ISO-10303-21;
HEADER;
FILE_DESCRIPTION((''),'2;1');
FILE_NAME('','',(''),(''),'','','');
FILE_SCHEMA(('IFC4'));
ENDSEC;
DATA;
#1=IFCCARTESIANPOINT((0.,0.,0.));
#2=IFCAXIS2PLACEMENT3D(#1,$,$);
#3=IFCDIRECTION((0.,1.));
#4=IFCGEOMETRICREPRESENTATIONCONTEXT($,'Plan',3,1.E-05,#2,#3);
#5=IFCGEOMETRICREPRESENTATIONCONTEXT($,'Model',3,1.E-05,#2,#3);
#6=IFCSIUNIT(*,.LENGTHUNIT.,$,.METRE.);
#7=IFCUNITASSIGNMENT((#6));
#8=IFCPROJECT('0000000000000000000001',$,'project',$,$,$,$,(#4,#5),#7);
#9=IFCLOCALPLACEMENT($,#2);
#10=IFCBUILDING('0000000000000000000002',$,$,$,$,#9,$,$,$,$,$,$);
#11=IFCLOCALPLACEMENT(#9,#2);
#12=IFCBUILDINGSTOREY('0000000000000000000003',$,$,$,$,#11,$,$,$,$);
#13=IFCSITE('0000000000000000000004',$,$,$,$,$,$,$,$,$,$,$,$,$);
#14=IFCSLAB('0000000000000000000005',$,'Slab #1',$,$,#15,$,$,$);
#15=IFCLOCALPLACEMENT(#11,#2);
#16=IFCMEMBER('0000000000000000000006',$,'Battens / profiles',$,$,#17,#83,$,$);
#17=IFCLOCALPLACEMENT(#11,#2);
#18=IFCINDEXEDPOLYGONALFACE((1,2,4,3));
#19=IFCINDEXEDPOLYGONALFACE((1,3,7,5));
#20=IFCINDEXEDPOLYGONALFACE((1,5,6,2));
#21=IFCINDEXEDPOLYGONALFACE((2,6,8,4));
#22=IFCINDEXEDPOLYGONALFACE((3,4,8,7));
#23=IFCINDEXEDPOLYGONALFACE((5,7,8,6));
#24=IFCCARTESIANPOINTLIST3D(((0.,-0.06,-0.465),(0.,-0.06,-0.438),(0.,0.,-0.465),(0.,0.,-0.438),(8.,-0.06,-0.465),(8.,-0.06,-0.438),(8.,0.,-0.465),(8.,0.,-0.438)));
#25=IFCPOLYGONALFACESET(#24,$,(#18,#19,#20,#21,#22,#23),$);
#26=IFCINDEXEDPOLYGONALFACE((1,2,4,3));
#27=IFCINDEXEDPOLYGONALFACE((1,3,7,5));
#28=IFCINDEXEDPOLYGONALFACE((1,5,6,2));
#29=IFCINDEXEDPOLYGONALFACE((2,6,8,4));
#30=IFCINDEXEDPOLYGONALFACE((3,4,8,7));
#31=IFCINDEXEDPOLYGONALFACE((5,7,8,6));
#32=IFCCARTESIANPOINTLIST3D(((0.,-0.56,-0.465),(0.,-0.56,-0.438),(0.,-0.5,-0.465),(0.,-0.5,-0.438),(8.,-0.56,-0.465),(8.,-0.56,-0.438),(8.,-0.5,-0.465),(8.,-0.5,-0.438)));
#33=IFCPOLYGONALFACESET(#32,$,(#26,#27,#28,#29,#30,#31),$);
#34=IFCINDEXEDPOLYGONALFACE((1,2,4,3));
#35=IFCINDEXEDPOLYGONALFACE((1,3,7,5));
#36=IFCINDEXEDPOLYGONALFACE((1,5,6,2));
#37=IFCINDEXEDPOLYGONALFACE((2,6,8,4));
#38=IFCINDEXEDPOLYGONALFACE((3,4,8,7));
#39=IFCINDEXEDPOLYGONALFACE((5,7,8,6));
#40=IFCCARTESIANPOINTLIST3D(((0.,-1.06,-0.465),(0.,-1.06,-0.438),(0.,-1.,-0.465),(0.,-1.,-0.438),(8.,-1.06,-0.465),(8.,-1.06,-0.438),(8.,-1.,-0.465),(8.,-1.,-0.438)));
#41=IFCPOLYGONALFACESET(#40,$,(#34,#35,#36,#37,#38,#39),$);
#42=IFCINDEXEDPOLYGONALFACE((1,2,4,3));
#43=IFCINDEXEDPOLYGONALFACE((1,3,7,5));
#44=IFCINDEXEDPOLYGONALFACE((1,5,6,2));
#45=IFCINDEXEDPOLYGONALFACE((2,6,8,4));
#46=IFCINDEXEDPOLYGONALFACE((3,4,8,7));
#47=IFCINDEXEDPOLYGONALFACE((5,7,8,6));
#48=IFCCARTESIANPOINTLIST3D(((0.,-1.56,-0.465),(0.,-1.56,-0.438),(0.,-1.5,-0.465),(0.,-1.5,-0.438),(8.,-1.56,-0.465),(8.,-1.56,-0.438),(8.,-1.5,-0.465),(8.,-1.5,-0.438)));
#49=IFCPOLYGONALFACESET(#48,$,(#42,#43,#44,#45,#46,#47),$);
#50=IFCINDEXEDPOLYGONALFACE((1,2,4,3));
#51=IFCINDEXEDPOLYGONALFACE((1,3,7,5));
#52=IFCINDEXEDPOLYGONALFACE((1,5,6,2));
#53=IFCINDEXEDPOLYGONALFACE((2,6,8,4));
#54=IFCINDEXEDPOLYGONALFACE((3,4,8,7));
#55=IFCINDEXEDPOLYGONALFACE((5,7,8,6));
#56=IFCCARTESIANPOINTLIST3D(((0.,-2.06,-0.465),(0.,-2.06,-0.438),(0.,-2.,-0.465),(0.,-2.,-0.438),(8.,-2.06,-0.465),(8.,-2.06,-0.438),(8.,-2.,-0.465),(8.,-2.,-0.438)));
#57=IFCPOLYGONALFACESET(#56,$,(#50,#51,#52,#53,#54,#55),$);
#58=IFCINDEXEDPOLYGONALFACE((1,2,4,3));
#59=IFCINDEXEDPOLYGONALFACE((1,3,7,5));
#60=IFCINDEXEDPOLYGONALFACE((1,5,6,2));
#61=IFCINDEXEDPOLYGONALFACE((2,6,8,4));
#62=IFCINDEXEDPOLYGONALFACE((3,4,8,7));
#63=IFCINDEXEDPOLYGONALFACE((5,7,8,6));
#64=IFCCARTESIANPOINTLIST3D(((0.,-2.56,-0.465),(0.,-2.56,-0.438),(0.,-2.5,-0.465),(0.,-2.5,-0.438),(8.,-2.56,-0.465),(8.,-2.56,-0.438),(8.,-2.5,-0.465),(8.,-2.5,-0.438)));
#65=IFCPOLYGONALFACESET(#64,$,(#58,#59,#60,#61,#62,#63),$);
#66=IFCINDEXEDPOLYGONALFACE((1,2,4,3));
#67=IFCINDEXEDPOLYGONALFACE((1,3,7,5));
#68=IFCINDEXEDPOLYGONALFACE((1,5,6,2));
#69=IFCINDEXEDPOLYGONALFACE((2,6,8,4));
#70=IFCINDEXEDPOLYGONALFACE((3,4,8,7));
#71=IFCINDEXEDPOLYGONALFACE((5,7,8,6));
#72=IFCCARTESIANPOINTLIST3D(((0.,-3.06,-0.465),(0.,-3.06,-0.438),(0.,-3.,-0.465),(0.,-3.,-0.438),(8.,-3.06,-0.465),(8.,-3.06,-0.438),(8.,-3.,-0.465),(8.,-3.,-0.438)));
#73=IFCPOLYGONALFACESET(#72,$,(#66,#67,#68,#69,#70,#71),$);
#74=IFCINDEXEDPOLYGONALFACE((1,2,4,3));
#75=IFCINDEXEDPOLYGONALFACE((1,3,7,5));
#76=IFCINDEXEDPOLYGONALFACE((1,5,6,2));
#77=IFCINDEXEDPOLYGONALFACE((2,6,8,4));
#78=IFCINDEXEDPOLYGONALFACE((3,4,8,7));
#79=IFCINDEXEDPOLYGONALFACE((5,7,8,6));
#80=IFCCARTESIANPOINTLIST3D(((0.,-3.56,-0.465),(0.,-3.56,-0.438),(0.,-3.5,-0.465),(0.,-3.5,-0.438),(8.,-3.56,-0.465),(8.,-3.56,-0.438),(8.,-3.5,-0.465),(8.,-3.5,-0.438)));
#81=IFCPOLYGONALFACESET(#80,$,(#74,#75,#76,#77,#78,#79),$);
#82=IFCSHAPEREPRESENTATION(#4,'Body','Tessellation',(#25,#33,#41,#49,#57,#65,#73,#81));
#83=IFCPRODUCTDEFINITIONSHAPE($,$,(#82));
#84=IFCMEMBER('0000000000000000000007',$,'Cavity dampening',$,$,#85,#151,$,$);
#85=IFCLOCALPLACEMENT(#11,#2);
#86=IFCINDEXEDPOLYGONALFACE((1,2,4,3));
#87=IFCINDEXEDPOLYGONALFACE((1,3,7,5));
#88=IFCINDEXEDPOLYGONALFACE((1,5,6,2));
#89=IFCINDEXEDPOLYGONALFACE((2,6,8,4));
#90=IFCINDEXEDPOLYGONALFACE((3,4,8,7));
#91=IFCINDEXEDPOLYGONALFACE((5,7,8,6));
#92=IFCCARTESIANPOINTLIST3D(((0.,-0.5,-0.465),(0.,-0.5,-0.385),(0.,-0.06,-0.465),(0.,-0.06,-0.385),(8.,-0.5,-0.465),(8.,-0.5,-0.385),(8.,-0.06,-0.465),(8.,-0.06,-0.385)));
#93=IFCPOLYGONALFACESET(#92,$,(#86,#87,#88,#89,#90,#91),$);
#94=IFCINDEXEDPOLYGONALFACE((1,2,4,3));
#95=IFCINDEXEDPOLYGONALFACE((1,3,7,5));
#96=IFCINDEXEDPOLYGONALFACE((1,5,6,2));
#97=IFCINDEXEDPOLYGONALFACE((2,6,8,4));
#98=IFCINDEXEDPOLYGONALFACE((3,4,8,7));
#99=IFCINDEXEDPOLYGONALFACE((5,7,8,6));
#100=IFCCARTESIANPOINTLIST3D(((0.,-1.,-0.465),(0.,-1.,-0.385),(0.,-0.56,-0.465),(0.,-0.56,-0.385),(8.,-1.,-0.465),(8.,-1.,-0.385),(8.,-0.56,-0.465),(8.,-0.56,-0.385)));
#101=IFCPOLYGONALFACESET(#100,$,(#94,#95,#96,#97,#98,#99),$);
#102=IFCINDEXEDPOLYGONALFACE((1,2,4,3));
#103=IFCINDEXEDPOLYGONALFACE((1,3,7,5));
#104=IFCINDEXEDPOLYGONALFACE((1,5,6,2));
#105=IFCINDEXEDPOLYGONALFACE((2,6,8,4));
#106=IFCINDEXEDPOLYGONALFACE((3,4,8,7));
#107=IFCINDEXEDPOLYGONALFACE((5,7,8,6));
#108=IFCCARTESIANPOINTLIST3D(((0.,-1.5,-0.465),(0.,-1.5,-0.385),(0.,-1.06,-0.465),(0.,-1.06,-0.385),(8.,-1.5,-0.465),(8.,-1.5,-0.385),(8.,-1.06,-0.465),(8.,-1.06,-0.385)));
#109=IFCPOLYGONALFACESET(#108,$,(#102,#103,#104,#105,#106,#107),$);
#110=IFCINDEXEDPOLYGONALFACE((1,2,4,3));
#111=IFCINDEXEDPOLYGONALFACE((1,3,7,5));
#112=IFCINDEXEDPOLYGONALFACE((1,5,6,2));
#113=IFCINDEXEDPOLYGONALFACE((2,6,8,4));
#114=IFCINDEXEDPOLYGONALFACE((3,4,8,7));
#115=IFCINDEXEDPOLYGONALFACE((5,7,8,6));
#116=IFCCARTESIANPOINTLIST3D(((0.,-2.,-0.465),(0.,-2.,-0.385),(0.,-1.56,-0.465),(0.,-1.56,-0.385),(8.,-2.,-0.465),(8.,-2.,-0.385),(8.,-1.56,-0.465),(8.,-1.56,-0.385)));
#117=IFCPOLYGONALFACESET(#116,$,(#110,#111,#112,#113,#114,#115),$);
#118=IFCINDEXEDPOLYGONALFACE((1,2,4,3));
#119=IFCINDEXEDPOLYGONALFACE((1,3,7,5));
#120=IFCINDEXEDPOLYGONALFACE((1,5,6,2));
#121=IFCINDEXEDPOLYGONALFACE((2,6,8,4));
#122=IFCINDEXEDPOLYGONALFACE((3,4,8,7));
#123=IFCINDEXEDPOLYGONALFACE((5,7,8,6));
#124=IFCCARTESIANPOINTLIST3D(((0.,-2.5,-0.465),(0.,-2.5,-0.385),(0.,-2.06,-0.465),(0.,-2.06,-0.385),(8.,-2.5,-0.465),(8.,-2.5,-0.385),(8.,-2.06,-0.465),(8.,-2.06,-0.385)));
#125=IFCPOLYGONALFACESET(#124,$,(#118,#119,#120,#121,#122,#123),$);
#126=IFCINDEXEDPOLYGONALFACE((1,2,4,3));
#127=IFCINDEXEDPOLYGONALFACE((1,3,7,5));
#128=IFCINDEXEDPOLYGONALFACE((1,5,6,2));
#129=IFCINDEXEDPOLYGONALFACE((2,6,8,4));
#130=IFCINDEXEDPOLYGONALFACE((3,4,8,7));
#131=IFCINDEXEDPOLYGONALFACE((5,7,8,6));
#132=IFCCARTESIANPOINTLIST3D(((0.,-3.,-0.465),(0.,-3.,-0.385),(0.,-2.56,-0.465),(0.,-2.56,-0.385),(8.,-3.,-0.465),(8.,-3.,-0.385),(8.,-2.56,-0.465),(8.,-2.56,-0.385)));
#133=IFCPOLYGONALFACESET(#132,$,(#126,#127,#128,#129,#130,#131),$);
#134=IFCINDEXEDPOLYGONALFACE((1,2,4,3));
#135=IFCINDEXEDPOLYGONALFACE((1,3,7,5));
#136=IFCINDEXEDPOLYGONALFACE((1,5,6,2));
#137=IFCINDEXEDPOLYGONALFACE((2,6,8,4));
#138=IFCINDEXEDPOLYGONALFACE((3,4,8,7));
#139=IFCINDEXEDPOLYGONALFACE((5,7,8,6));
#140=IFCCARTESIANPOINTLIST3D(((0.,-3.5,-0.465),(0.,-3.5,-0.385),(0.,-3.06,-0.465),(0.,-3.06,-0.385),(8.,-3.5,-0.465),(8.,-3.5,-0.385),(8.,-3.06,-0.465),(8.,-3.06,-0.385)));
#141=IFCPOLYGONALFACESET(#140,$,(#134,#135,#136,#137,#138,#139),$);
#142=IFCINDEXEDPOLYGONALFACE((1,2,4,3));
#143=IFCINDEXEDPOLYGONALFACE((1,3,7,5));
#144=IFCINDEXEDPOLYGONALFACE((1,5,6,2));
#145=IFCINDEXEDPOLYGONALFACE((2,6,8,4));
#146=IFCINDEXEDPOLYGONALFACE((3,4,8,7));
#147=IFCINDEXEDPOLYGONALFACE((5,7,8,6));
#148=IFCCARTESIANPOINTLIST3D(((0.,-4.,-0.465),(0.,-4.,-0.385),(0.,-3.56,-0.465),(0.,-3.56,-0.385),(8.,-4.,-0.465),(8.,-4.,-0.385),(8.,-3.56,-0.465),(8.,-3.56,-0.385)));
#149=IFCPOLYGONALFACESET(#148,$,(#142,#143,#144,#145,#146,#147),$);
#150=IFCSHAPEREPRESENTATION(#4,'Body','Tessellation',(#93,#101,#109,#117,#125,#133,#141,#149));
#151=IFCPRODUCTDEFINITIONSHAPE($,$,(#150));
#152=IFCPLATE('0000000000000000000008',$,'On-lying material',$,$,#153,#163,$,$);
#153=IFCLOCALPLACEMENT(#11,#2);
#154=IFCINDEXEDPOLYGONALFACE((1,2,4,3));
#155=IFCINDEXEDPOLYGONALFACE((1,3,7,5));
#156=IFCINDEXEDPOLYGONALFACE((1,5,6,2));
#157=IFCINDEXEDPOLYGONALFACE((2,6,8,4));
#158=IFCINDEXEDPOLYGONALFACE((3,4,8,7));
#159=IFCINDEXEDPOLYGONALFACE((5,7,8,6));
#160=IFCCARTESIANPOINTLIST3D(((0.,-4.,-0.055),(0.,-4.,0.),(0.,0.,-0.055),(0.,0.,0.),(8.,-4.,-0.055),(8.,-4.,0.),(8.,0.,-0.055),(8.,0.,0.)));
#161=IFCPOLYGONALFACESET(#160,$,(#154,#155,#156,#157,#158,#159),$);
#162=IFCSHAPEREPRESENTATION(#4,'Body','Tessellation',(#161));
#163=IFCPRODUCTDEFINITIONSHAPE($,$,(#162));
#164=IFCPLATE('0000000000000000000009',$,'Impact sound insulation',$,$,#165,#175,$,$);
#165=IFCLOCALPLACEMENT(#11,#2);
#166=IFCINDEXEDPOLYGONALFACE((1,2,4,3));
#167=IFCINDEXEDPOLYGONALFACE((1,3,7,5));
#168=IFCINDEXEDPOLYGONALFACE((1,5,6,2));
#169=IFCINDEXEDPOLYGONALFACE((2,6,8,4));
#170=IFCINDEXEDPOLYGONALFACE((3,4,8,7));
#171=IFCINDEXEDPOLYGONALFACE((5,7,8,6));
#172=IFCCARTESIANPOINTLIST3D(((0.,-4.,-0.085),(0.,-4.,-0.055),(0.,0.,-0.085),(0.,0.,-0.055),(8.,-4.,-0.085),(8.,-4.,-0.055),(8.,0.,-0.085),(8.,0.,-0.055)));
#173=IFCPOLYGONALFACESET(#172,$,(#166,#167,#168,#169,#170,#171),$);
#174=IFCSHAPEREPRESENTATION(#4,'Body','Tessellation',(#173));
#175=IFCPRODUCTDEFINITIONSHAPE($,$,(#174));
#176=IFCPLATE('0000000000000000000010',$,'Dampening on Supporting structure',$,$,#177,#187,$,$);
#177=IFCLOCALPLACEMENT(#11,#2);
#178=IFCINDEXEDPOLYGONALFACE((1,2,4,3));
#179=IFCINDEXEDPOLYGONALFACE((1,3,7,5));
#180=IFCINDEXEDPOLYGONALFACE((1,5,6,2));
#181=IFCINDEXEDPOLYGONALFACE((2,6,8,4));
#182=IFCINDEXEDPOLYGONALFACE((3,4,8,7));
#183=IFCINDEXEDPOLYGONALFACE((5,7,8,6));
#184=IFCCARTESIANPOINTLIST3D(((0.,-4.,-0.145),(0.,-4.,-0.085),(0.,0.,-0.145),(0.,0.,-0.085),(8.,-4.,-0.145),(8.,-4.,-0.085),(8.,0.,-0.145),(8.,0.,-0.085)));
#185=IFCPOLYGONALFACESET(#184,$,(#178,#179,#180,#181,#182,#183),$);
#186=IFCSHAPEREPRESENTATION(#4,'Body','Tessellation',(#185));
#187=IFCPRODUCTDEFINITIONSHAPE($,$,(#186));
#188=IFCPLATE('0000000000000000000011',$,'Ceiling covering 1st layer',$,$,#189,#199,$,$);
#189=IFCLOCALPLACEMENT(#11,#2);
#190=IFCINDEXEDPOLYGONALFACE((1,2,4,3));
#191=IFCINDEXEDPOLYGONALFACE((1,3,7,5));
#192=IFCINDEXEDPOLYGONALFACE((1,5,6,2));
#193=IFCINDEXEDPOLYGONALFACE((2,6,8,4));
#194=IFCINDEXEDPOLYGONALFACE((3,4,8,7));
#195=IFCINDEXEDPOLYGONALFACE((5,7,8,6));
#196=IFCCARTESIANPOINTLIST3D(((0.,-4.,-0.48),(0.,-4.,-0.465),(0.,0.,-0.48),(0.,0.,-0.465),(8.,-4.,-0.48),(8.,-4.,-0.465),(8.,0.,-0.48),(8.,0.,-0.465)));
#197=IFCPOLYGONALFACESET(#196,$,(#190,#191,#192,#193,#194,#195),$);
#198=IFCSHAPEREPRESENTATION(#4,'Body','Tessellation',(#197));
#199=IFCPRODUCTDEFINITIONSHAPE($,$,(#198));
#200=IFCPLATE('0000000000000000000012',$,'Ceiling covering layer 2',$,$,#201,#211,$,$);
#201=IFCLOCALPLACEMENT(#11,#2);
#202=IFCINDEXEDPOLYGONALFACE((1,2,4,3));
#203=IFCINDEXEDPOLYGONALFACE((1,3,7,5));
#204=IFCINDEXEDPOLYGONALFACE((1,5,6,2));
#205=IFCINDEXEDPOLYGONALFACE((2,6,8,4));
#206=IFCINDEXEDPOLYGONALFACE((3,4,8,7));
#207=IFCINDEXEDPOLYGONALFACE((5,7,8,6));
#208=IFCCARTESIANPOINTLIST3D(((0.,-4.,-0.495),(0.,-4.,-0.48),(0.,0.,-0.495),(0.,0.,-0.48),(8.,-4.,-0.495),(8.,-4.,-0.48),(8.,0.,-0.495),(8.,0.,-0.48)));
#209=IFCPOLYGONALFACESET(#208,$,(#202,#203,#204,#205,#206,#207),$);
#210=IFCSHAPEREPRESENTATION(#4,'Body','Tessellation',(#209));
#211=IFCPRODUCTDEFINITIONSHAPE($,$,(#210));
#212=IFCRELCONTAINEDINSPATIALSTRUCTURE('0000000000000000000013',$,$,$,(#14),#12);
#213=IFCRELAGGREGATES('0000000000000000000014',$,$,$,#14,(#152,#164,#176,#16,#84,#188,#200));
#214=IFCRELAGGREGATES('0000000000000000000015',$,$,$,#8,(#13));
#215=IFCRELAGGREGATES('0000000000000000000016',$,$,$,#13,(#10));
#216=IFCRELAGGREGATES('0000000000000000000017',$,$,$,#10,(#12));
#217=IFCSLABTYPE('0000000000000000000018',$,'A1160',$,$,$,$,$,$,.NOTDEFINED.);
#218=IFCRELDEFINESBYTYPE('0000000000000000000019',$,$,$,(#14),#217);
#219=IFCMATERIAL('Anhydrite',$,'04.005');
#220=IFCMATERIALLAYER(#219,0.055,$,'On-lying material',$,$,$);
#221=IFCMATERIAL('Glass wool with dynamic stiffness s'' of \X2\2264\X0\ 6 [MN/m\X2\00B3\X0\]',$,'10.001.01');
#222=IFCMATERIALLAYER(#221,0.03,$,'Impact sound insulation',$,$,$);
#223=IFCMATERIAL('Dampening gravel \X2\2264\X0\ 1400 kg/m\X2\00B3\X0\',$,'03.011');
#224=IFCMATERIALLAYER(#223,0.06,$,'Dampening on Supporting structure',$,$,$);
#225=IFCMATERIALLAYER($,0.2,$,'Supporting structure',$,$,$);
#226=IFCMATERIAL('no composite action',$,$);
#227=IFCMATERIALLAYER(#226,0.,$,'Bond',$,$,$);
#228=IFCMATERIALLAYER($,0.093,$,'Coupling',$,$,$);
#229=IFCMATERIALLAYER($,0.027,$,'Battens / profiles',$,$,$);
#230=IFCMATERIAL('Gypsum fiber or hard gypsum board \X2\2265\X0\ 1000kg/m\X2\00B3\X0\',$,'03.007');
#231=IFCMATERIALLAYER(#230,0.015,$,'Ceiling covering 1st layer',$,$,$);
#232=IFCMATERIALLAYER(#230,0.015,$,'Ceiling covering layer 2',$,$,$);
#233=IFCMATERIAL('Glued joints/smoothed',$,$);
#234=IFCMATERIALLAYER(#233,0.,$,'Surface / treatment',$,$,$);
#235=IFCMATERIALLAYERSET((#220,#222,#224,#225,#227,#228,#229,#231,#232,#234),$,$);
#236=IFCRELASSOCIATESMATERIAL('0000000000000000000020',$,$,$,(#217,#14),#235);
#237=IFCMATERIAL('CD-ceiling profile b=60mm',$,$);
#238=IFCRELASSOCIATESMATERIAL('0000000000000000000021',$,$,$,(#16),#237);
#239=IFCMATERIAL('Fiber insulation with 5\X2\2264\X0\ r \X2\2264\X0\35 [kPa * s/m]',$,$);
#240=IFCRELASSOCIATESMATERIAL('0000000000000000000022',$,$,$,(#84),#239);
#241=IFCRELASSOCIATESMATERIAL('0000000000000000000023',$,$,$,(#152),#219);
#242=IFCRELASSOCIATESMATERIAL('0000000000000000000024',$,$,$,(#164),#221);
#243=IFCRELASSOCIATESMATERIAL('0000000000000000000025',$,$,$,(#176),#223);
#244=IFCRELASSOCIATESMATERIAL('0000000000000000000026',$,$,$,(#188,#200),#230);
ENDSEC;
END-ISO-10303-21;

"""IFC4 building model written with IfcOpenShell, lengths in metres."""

from ifc_helpers import new_model, si_unit, direction, frame, frame_2d, origin, origin_with_axes, place, context, project, spatial, rectangle, extrude, material, layer, layer_set, type_object, element, aggregate, save


model = new_model("IFC4")

# Units and contexts
plan_context = context("Plan", 3, precision=1e-05, world=origin(), true_north=direction((0.0, 1.0)))
model_context = context("Model", 3, precision=1e-05, world=origin(), true_north=direction((0.0, 1.0)))
ifc_project = project(units=[si_unit("LENGTHUNIT", "METRE")], contexts=[plan_context, model_context])

# Site, building, storey
site = spatial("IfcSite", under=ifc_project)
building_placement = place(None, origin())
building = spatial("IfcBuilding", under=site, at=building_placement)
storey_placement = place(building_placement, origin())
storey = spatial("IfcBuildingStorey", under=building, at=storey_placement)

# Slab, members, plates
ifc_material_1 = material(Name="Anhydrite", Category="04.005")
ifc_layer_1 = layer(ifc_material_1, 0.055, Name="On-lying material")
ifc_material_2 = material(Name="Glass wool with dynamic stiffness s' of ≤ 6 [MN/m³]", Category="10.001.01")
ifc_layer_2 = layer(ifc_material_2, 0.03, Name="Impact sound insulation")
ifc_material_3 = material(Name="Dampening gravel ≤ 1400 kg/m³", Category="03.011")
ifc_layer_3 = layer(ifc_material_3, 0.06, Name="Dampening on Supporting structure")
ifc_layer_4 = layer(None, 0.2, Name="Supporting structure")
ifc_material_4 = material(Name="no composite action")
ifc_layer_5 = layer(ifc_material_4, 0.0, Name="Bond")
ifc_layer_6 = layer(None, 0.093, Name="Coupling")
ifc_layer_7 = layer(None, 0.027, Name="Battens / profiles")
ifc_material_5 = material(Name="Gypsum fiber or hard gypsum board ≥ 1000kg/m³", Category="03.007")
ifc_layer_8 = layer(ifc_material_5, 0.015, Name="Ceiling covering 1st layer")
ifc_layer_9 = layer(ifc_material_5, 0.015, Name="Ceiling covering layer 2")
ifc_material_6 = material(Name="Glued joints/smoothed")
ifc_layer_10 = layer(ifc_material_6, 0.0, Name="Surface / treatment")
ifc_layer_set = layer_set([ifc_layer_1, ifc_layer_2, ifc_layer_3, ifc_layer_4, ifc_layer_5, ifc_layer_6, ifc_layer_7, ifc_layer_8, ifc_layer_9, ifc_layer_10])
slab_type = type_object("IfcSlabType", Name="A1160", PredefinedType="NOTDEFINED", material=ifc_layer_set)
slab_placement = place(None, frame((0.0, 0.0, 0.0), z_axis=(0.0, 0.0, -1.0), x_axis=(1.0, 0.0, 0.0)))
slab = element("IfcSlab", 1, at=slab_placement, inside=storey, type_object=slab_type, material=ifc_layer_set, Name="Slab #1")
ifc_material_7 = material(Name="CD-ceiling profile b=60mm")
member_1_placement = place(slab_placement, origin())
member_1 = element("IfcMember", 2, at=member_1_placement, material=ifc_material_7, Name="Battens / profiles", context=plan_context, shape_type="SweptSolid", body=[
    extrude(rectangle(XDim=0.06, YDim=0.027, at=frame_2d((0.03, 0.0135), x_axis=(1.0, 0.0))), frame((0.0, 0.0, 0.438), z_axis=(1.0, 0.0, 0.0), x_axis=(0.0, 1.0, 0.0)), (0.0, 0.0, 1.0), 8.0),
    extrude(rectangle(XDim=0.06, YDim=0.027, at=frame_2d((0.03, 0.0135), x_axis=(1.0, 0.0))), frame((0.0, 0.5, 0.438), z_axis=(1.0, 0.0, 0.0), x_axis=(0.0, 1.0, 0.0)), (0.0, 0.0, 1.0), 8.0),
    extrude(rectangle(XDim=0.06, YDim=0.027, at=frame_2d((0.03, 0.0135), x_axis=(1.0, 0.0))), frame((0.0, 1.0, 0.438), z_axis=(1.0, 0.0, 0.0), x_axis=(0.0, 1.0, 0.0)), (0.0, 0.0, 1.0), 8.0),
    extrude(rectangle(XDim=0.06, YDim=0.027, at=frame_2d((0.03, 0.0135), x_axis=(1.0, 0.0))), frame((0.0, 1.5, 0.438), z_axis=(1.0, 0.0, 0.0), x_axis=(0.0, 1.0, 0.0)), (0.0, 0.0, 1.0), 8.0),
    extrude(rectangle(XDim=0.06, YDim=0.027, at=frame_2d((0.03, 0.0135), x_axis=(1.0, 0.0))), frame((0.0, 2.0, 0.438), z_axis=(1.0, 0.0, 0.0), x_axis=(0.0, 1.0, 0.0)), (0.0, 0.0, 1.0), 8.0),
    extrude(rectangle(XDim=0.06, YDim=0.027, at=frame_2d((0.03, 0.0135), x_axis=(1.0, 0.0))), frame((0.0, 2.5, 0.438), z_axis=(1.0, 0.0, 0.0), x_axis=(0.0, 1.0, 0.0)), (0.0, 0.0, 1.0), 8.0),
    extrude(rectangle(XDim=0.06, YDim=0.027, at=frame_2d((0.03, 0.0135), x_axis=(1.0, 0.0))), frame((0.0, 3.0, 0.438), z_axis=(1.0, 0.0, 0.0), x_axis=(0.0, 1.0, 0.0)), (0.0, 0.0, 1.0), 8.0),
    extrude(rectangle(XDim=0.06, YDim=0.027, at=frame_2d((0.03, 0.0135), x_axis=(1.0, 0.0))), frame((0.0, 3.5, 0.438), z_axis=(1.0, 0.0, 0.0), x_axis=(0.0, 1.0, 0.0)), (0.0, 0.0, 1.0), 8.0),
])
ifc_material_8 = material(Name="Fiber insulation with 5≤ r ≤35 [kPa * s/m]")
member_2_placement = place(slab_placement, origin())
member_2 = element("IfcMember", 3, at=member_2_placement, material=ifc_material_8, Name="Cavity dampening", context=plan_context, shape_type="SweptSolid", body=[
    extrude(rectangle(XDim=0.44, YDim=0.08, at=frame_2d((0.22, 0.04), x_axis=(1.0, 0.0))), frame((0.0, 0.06, 0.385), z_axis=(1.0, 0.0, 0.0), x_axis=(0.0, 1.0, 0.0)), (0.0, 0.0, 1.0), 8.0),
    extrude(rectangle(XDim=0.44, YDim=0.08, at=frame_2d((0.22, 0.04), x_axis=(1.0, 0.0))), frame((0.0, 0.56, 0.385), z_axis=(1.0, 0.0, 0.0), x_axis=(0.0, 1.0, 0.0)), (0.0, 0.0, 1.0), 8.0),
    extrude(rectangle(XDim=0.44, YDim=0.08, at=frame_2d((0.22, 0.04), x_axis=(1.0, 0.0))), frame((0.0, 1.06, 0.385), z_axis=(1.0, 0.0, 0.0), x_axis=(0.0, 1.0, 0.0)), (0.0, 0.0, 1.0), 8.0),
    extrude(rectangle(XDim=0.44, YDim=0.08, at=frame_2d((0.22, 0.04), x_axis=(1.0, 0.0))), frame((0.0, 1.56, 0.385), z_axis=(1.0, 0.0, 0.0), x_axis=(0.0, 1.0, 0.0)), (0.0, 0.0, 1.0), 8.0),
    extrude(rectangle(XDim=0.44, YDim=0.08, at=frame_2d((0.22, 0.04), x_axis=(1.0, 0.0))), frame((0.0, 2.06, 0.385), z_axis=(1.0, 0.0, 0.0), x_axis=(0.0, 1.0, 0.0)), (0.0, 0.0, 1.0), 8.0),
    extrude(rectangle(XDim=0.44, YDim=0.08, at=frame_2d((0.22, 0.04), x_axis=(1.0, 0.0))), frame((0.0, 2.56, 0.385), z_axis=(1.0, 0.0, 0.0), x_axis=(0.0, 1.0, 0.0)), (0.0, 0.0, 1.0), 8.0),
    extrude(rectangle(XDim=0.44, YDim=0.08, at=frame_2d((0.22, 0.04), x_axis=(1.0, 0.0))), frame((0.0, 3.06, 0.385), z_axis=(1.0, 0.0, 0.0), x_axis=(0.0, 1.0, 0.0)), (0.0, 0.0, 1.0), 8.0),
    extrude(rectangle(XDim=0.44, YDim=0.08, at=frame_2d((0.22, 0.04), x_axis=(1.0, 0.0))), frame((0.0, 3.56, 0.385), z_axis=(1.0, 0.0, 0.0), x_axis=(0.0, 1.0, 0.0)), (0.0, 0.0, 1.0), 8.0),
])
plate_1_placement = place(slab_placement, origin())
plate_1 = element("IfcPlate", 4, at=plate_1_placement, material=ifc_material_1, Name="On-lying material", context=plan_context, shape_type="SweptSolid", body=[
    extrude(rectangle(XDim=8.0, YDim=4.0, at=frame_2d((4.0, 2.0), x_axis=(1.0, 0.0))), origin_with_axes(), (0.0, 0.0, 1.0), 0.055),
])
plate_2_placement = place(slab_placement, origin())
plate_2 = element("IfcPlate", 5, at=plate_2_placement, material=ifc_material_2, Name="Impact sound insulation", context=plan_context, shape_type="SweptSolid", body=[
    extrude(rectangle(XDim=8.0, YDim=4.0, at=frame_2d((4.0, 2.0), x_axis=(1.0, 0.0))), frame((0.0, 0.0, 0.055), z_axis=(0.0, 0.0, 1.0), x_axis=(1.0, 0.0, 0.0)), (0.0, 0.0, 1.0), 0.03),
])
plate_3_placement = place(slab_placement, origin())
plate_3 = element("IfcPlate", 6, at=plate_3_placement, material=ifc_material_3, Name="Dampening on Supporting structure", context=plan_context, shape_type="SweptSolid", body=[
    extrude(rectangle(XDim=8.0, YDim=4.0, at=frame_2d((4.0, 2.0), x_axis=(1.0, 0.0))), frame((0.0, 0.0, 0.085), z_axis=(0.0, 0.0, 1.0), x_axis=(1.0, 0.0, 0.0)), (0.0, 0.0, 1.0), 0.06),
])
plate_4_placement = place(slab_placement, origin())
plate_4 = element("IfcPlate", 7, at=plate_4_placement, material=ifc_material_5, Name="Ceiling covering 1st layer", context=plan_context, shape_type="SweptSolid", body=[
    extrude(rectangle(XDim=8.0, YDim=4.0, at=frame_2d((4.0, 2.0), x_axis=(1.0, 0.0))), frame((0.0, 0.0, 0.465), z_axis=(0.0, 0.0, 1.0), x_axis=(1.0, 0.0, 0.0)), (0.0, 0.0, 1.0), 0.015),
])
plate_5_placement = place(slab_placement, origin())
plate_5 = element("IfcPlate", 8, at=plate_5_placement, material=ifc_material_5, Name="Ceiling covering layer 2", context=plan_context, shape_type="SweptSolid", body=[
    extrude(rectangle(XDim=8.0, YDim=4.0, at=frame_2d((4.0, 2.0), x_axis=(1.0, 0.0))), frame((0.0, 0.0, 0.48), z_axis=(0.0, 0.0, 1.0), x_axis=(1.0, 0.0, 0.0)), (0.0, 0.0, 1.0), 0.015),
])
aggregate(slab, [plate_1, plate_2, plate_3, member_1, member_2, plate_4, plate_5])

save(model, "model.ifc")
